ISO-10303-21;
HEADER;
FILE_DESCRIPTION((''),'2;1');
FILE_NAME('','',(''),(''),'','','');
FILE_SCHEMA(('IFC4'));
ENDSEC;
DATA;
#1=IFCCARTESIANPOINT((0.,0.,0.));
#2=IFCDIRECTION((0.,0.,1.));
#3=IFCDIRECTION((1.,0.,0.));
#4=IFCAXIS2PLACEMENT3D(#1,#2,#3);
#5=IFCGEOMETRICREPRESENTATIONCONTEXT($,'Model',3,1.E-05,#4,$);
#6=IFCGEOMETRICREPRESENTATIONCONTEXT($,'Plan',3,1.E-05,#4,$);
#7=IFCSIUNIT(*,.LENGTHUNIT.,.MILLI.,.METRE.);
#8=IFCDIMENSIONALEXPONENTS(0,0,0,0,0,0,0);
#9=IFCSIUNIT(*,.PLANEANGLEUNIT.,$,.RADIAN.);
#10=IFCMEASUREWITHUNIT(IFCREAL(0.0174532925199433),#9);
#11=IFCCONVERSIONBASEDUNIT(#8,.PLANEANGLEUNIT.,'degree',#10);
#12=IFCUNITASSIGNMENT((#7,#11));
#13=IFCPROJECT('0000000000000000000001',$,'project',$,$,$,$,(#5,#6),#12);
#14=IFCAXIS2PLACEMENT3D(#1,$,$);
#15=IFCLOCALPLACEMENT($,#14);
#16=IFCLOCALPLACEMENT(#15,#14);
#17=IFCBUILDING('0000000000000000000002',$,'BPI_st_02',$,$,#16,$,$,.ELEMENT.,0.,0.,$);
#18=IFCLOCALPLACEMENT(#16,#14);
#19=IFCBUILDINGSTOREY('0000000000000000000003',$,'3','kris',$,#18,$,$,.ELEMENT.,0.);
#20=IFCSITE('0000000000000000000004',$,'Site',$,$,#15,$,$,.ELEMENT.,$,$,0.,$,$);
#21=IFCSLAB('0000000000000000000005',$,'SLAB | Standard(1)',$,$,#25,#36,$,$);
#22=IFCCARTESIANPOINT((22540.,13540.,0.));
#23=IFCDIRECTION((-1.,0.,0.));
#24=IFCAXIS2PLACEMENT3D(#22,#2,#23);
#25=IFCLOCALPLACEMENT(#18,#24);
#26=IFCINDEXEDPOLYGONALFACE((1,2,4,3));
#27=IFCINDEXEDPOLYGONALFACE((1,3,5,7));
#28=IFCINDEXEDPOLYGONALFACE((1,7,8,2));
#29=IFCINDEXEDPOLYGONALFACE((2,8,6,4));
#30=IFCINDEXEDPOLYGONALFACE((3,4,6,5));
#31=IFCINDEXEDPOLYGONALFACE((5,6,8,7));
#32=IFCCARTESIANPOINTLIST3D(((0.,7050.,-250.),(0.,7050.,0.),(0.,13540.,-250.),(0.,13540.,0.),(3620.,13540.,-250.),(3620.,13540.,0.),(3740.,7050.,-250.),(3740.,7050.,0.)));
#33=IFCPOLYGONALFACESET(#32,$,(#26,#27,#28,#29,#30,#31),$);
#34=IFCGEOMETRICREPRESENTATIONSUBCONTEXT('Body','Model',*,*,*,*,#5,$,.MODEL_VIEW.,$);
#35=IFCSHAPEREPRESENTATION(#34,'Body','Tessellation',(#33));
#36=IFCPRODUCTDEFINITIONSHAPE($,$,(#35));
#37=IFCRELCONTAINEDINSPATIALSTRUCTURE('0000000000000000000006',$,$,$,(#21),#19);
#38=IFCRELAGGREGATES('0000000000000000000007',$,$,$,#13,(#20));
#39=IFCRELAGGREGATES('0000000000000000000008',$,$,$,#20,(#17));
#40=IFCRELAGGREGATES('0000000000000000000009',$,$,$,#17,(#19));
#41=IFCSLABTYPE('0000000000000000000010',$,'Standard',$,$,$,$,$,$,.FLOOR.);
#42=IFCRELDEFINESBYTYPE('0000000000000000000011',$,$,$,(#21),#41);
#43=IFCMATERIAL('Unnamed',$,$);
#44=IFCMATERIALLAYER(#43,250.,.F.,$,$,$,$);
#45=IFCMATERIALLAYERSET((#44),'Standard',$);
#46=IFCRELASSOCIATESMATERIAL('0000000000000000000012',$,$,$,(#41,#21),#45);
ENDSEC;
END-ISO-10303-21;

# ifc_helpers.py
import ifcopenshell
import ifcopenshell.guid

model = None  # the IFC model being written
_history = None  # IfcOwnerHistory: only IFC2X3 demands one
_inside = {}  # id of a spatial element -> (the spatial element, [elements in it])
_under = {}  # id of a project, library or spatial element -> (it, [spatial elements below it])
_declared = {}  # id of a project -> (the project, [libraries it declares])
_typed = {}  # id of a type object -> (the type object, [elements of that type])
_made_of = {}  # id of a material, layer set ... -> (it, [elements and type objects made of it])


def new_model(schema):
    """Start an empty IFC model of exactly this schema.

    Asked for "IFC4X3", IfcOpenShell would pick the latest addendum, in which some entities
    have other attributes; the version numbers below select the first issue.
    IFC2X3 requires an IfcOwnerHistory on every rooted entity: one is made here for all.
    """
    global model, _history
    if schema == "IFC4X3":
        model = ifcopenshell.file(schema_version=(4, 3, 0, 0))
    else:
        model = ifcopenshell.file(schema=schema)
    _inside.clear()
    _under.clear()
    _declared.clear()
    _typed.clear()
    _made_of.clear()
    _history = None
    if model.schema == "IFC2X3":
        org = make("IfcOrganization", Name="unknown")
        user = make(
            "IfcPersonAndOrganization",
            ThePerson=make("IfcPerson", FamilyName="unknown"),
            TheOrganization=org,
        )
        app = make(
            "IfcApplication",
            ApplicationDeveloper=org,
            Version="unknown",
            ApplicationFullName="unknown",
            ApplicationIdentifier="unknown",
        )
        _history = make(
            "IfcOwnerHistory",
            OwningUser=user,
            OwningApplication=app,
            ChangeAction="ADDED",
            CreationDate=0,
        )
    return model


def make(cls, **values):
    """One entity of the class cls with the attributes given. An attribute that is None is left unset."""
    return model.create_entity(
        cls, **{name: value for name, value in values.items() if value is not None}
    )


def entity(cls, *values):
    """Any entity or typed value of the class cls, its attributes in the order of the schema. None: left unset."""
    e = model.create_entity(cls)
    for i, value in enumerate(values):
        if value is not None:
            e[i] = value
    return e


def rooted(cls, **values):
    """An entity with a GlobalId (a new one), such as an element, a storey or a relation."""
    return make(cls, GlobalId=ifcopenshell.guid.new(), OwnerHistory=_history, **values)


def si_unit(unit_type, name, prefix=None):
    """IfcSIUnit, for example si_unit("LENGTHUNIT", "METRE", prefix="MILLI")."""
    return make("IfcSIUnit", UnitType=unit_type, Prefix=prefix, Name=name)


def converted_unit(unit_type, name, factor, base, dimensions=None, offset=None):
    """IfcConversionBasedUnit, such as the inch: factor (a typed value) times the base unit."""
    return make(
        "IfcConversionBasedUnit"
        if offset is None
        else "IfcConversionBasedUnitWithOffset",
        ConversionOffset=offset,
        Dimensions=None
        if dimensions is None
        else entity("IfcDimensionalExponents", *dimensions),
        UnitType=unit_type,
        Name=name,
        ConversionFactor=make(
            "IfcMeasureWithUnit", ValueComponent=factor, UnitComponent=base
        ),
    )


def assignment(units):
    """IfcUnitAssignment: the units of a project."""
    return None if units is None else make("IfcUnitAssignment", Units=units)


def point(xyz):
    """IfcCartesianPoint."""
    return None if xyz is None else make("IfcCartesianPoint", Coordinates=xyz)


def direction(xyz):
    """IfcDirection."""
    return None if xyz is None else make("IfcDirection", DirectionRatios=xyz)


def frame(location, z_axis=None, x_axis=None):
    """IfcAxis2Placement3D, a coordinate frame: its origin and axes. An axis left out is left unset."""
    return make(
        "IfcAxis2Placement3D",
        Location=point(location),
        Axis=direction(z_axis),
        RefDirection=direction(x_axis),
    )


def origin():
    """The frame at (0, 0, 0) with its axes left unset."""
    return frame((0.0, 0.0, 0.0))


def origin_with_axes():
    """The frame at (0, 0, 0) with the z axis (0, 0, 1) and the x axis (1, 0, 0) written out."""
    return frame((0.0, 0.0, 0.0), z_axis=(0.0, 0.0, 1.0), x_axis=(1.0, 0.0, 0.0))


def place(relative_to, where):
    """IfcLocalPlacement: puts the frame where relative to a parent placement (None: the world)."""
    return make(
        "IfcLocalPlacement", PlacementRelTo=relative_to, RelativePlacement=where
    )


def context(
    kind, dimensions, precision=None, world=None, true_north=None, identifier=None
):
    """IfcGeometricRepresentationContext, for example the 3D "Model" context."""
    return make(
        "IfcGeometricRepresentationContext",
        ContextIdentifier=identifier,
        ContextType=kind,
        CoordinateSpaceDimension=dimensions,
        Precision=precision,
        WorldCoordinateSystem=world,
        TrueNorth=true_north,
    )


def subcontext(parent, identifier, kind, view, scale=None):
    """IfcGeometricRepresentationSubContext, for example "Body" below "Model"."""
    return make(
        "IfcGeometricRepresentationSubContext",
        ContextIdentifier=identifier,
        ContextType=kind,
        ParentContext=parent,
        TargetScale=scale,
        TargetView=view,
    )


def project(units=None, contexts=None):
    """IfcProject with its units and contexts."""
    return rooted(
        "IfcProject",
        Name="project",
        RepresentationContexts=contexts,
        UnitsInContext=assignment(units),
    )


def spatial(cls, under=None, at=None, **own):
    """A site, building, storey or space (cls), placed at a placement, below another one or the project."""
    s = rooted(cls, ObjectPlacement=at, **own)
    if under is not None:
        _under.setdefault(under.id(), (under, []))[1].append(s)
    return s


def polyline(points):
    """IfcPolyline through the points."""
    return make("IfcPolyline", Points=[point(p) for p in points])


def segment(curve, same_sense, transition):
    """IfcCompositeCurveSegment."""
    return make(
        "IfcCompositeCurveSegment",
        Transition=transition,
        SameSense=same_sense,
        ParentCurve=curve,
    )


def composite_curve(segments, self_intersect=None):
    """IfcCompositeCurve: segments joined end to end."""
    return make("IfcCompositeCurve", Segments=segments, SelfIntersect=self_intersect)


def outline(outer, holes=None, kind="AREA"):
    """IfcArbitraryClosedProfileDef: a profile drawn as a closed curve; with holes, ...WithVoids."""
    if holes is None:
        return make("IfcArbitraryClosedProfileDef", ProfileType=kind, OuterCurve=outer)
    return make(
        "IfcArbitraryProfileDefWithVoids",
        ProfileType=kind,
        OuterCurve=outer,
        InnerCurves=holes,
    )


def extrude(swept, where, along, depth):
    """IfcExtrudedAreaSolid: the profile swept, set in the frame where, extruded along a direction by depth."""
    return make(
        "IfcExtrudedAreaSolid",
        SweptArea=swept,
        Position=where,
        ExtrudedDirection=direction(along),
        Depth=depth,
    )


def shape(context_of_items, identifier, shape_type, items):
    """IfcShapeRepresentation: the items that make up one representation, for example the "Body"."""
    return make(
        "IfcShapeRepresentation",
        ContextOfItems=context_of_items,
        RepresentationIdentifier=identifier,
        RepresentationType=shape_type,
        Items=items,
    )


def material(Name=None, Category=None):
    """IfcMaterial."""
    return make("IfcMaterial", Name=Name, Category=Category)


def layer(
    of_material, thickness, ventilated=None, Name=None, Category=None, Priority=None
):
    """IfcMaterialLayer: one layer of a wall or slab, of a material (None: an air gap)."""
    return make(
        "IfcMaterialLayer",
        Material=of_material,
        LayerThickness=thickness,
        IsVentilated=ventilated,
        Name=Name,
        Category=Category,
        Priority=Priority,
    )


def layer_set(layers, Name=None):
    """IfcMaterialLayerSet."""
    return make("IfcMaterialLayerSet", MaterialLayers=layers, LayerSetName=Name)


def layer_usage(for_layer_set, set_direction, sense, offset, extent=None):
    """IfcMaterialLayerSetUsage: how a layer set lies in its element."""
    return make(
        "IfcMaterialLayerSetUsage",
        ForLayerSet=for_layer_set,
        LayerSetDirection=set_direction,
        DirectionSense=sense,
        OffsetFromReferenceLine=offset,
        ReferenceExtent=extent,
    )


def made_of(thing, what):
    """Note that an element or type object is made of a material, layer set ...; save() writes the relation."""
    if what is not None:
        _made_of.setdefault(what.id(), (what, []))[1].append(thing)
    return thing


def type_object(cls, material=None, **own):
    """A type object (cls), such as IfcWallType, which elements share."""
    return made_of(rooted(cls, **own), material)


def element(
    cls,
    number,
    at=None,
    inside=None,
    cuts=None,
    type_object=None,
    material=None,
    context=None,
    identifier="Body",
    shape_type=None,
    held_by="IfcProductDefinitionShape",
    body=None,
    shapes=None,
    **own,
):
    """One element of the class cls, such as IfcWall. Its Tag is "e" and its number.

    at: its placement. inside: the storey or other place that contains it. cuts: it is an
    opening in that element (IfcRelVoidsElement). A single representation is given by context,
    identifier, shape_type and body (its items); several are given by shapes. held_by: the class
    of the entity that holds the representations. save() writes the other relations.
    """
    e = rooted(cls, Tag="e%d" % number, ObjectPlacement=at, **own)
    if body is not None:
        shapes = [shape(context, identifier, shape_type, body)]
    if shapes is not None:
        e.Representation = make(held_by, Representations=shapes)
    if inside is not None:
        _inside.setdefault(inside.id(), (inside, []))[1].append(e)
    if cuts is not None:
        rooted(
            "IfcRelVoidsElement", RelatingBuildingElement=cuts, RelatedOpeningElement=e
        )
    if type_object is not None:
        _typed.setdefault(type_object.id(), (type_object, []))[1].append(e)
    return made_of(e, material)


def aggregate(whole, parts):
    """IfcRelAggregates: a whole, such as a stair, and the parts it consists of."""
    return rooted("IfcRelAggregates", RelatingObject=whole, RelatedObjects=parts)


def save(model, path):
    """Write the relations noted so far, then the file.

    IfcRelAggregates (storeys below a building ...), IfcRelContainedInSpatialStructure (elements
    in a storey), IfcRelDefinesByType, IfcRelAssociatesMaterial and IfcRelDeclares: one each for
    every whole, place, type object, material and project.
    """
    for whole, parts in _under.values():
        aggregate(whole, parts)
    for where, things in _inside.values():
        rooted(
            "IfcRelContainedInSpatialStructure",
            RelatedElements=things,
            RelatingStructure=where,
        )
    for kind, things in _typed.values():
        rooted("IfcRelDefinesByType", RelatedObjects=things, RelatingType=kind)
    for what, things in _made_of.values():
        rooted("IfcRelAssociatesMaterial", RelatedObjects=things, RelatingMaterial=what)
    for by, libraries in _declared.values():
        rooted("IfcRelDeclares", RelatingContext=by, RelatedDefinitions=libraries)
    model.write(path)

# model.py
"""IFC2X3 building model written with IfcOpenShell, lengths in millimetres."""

from ifc_helpers import new_model, entity, si_unit, converted_unit, frame, origin, origin_with_axes, place, context, subcontext, project, spatial, polyline, segment, composite_curve, outline, extrude, material, layer, layer_set, layer_usage, type_object, element, save


model = new_model("IFC2X3")

# Units and contexts
model_context = context("Model", 3, precision=1e-05, world=origin_with_axes())
plan_context = context("Plan", 3, precision=1e-05, world=origin_with_axes())
body_context = subcontext(model_context, "Body", "Model", "MODEL_VIEW")
ifc_project = project(units=[si_unit("LENGTHUNIT", "METRE", prefix="MILLI"), converted_unit("PLANEANGLEUNIT", "degree", entity("IfcReal", 0.0174532925199433), si_unit("PLANEANGLEUNIT", "RADIAN"), dimensions=[0, 0, 0, 0, 0, 0, 0])], contexts=[model_context, plan_context])

# Site, building, storey
site_placement = place(None, origin())
site = spatial("IfcSite", under=ifc_project, at=site_placement, Name="Site", CompositionType="ELEMENT", RefElevation=0.0)
building_placement = place(site_placement, origin())
building = spatial("IfcBuilding", under=site, at=building_placement, Name="BPI_st_02", CompositionType="ELEMENT", ElevationOfRefHeight=0.0, ElevationOfTerrain=0.0)
storey_placement = place(building_placement, origin())
storey = spatial("IfcBuildingStorey", under=building, at=storey_placement, Name="3", Description="kris", CompositionType="ELEMENT", Elevation=0.0)

# Slab
ifc_material = material(Name="Unnamed")
ifc_layer_1 = layer(ifc_material, 250.0, ventilated=False)
ifc_layer_set_1 = layer_set([ifc_layer_1], Name="Standard")
ifc_layer_usage_1 = layer_usage(ifc_layer_set_1, "AXIS3", "POSITIVE", 0.0)
slab_type = type_object("IfcSlabType", Name="Standard", PredefinedType="FLOOR", material=ifc_layer_set_1)
slab_placement = place(storey_placement, frame((22540.0, 13540.0, 0.0), z_axis=(0.0, 0.0, 1.0), x_axis=(-1.0, 0.0, 0.0)))
element("IfcSlab", 1, at=slab_placement, inside=storey, type_object=slab_type, material=ifc_layer_usage_1, Name="SLAB | Standard(1)", context=body_context, shape_type="SweptSolid", body=[
    extrude(outline(composite_curve([segment(polyline([(0.0, 7050.0), (3740.0, 7050.0)]), True, "CONTINUOUS"), segment(polyline([(3740.0, 7050.0), (3620.0, 13540.0)]), True, "CONTINUOUS"), segment(polyline([(3620.0, 13540.0), (0.0, 13540.0)]), True, "CONTINUOUS"), segment(polyline([(0.0, 13540.0), (0.0, 7050.0)]), True, "CONTINUOUS")], self_intersect=False)), frame((0.0, 0.0, -250.0)), (0.0, 0.0, 1.0), 250.0),
])

save(model, "model.ifc")
